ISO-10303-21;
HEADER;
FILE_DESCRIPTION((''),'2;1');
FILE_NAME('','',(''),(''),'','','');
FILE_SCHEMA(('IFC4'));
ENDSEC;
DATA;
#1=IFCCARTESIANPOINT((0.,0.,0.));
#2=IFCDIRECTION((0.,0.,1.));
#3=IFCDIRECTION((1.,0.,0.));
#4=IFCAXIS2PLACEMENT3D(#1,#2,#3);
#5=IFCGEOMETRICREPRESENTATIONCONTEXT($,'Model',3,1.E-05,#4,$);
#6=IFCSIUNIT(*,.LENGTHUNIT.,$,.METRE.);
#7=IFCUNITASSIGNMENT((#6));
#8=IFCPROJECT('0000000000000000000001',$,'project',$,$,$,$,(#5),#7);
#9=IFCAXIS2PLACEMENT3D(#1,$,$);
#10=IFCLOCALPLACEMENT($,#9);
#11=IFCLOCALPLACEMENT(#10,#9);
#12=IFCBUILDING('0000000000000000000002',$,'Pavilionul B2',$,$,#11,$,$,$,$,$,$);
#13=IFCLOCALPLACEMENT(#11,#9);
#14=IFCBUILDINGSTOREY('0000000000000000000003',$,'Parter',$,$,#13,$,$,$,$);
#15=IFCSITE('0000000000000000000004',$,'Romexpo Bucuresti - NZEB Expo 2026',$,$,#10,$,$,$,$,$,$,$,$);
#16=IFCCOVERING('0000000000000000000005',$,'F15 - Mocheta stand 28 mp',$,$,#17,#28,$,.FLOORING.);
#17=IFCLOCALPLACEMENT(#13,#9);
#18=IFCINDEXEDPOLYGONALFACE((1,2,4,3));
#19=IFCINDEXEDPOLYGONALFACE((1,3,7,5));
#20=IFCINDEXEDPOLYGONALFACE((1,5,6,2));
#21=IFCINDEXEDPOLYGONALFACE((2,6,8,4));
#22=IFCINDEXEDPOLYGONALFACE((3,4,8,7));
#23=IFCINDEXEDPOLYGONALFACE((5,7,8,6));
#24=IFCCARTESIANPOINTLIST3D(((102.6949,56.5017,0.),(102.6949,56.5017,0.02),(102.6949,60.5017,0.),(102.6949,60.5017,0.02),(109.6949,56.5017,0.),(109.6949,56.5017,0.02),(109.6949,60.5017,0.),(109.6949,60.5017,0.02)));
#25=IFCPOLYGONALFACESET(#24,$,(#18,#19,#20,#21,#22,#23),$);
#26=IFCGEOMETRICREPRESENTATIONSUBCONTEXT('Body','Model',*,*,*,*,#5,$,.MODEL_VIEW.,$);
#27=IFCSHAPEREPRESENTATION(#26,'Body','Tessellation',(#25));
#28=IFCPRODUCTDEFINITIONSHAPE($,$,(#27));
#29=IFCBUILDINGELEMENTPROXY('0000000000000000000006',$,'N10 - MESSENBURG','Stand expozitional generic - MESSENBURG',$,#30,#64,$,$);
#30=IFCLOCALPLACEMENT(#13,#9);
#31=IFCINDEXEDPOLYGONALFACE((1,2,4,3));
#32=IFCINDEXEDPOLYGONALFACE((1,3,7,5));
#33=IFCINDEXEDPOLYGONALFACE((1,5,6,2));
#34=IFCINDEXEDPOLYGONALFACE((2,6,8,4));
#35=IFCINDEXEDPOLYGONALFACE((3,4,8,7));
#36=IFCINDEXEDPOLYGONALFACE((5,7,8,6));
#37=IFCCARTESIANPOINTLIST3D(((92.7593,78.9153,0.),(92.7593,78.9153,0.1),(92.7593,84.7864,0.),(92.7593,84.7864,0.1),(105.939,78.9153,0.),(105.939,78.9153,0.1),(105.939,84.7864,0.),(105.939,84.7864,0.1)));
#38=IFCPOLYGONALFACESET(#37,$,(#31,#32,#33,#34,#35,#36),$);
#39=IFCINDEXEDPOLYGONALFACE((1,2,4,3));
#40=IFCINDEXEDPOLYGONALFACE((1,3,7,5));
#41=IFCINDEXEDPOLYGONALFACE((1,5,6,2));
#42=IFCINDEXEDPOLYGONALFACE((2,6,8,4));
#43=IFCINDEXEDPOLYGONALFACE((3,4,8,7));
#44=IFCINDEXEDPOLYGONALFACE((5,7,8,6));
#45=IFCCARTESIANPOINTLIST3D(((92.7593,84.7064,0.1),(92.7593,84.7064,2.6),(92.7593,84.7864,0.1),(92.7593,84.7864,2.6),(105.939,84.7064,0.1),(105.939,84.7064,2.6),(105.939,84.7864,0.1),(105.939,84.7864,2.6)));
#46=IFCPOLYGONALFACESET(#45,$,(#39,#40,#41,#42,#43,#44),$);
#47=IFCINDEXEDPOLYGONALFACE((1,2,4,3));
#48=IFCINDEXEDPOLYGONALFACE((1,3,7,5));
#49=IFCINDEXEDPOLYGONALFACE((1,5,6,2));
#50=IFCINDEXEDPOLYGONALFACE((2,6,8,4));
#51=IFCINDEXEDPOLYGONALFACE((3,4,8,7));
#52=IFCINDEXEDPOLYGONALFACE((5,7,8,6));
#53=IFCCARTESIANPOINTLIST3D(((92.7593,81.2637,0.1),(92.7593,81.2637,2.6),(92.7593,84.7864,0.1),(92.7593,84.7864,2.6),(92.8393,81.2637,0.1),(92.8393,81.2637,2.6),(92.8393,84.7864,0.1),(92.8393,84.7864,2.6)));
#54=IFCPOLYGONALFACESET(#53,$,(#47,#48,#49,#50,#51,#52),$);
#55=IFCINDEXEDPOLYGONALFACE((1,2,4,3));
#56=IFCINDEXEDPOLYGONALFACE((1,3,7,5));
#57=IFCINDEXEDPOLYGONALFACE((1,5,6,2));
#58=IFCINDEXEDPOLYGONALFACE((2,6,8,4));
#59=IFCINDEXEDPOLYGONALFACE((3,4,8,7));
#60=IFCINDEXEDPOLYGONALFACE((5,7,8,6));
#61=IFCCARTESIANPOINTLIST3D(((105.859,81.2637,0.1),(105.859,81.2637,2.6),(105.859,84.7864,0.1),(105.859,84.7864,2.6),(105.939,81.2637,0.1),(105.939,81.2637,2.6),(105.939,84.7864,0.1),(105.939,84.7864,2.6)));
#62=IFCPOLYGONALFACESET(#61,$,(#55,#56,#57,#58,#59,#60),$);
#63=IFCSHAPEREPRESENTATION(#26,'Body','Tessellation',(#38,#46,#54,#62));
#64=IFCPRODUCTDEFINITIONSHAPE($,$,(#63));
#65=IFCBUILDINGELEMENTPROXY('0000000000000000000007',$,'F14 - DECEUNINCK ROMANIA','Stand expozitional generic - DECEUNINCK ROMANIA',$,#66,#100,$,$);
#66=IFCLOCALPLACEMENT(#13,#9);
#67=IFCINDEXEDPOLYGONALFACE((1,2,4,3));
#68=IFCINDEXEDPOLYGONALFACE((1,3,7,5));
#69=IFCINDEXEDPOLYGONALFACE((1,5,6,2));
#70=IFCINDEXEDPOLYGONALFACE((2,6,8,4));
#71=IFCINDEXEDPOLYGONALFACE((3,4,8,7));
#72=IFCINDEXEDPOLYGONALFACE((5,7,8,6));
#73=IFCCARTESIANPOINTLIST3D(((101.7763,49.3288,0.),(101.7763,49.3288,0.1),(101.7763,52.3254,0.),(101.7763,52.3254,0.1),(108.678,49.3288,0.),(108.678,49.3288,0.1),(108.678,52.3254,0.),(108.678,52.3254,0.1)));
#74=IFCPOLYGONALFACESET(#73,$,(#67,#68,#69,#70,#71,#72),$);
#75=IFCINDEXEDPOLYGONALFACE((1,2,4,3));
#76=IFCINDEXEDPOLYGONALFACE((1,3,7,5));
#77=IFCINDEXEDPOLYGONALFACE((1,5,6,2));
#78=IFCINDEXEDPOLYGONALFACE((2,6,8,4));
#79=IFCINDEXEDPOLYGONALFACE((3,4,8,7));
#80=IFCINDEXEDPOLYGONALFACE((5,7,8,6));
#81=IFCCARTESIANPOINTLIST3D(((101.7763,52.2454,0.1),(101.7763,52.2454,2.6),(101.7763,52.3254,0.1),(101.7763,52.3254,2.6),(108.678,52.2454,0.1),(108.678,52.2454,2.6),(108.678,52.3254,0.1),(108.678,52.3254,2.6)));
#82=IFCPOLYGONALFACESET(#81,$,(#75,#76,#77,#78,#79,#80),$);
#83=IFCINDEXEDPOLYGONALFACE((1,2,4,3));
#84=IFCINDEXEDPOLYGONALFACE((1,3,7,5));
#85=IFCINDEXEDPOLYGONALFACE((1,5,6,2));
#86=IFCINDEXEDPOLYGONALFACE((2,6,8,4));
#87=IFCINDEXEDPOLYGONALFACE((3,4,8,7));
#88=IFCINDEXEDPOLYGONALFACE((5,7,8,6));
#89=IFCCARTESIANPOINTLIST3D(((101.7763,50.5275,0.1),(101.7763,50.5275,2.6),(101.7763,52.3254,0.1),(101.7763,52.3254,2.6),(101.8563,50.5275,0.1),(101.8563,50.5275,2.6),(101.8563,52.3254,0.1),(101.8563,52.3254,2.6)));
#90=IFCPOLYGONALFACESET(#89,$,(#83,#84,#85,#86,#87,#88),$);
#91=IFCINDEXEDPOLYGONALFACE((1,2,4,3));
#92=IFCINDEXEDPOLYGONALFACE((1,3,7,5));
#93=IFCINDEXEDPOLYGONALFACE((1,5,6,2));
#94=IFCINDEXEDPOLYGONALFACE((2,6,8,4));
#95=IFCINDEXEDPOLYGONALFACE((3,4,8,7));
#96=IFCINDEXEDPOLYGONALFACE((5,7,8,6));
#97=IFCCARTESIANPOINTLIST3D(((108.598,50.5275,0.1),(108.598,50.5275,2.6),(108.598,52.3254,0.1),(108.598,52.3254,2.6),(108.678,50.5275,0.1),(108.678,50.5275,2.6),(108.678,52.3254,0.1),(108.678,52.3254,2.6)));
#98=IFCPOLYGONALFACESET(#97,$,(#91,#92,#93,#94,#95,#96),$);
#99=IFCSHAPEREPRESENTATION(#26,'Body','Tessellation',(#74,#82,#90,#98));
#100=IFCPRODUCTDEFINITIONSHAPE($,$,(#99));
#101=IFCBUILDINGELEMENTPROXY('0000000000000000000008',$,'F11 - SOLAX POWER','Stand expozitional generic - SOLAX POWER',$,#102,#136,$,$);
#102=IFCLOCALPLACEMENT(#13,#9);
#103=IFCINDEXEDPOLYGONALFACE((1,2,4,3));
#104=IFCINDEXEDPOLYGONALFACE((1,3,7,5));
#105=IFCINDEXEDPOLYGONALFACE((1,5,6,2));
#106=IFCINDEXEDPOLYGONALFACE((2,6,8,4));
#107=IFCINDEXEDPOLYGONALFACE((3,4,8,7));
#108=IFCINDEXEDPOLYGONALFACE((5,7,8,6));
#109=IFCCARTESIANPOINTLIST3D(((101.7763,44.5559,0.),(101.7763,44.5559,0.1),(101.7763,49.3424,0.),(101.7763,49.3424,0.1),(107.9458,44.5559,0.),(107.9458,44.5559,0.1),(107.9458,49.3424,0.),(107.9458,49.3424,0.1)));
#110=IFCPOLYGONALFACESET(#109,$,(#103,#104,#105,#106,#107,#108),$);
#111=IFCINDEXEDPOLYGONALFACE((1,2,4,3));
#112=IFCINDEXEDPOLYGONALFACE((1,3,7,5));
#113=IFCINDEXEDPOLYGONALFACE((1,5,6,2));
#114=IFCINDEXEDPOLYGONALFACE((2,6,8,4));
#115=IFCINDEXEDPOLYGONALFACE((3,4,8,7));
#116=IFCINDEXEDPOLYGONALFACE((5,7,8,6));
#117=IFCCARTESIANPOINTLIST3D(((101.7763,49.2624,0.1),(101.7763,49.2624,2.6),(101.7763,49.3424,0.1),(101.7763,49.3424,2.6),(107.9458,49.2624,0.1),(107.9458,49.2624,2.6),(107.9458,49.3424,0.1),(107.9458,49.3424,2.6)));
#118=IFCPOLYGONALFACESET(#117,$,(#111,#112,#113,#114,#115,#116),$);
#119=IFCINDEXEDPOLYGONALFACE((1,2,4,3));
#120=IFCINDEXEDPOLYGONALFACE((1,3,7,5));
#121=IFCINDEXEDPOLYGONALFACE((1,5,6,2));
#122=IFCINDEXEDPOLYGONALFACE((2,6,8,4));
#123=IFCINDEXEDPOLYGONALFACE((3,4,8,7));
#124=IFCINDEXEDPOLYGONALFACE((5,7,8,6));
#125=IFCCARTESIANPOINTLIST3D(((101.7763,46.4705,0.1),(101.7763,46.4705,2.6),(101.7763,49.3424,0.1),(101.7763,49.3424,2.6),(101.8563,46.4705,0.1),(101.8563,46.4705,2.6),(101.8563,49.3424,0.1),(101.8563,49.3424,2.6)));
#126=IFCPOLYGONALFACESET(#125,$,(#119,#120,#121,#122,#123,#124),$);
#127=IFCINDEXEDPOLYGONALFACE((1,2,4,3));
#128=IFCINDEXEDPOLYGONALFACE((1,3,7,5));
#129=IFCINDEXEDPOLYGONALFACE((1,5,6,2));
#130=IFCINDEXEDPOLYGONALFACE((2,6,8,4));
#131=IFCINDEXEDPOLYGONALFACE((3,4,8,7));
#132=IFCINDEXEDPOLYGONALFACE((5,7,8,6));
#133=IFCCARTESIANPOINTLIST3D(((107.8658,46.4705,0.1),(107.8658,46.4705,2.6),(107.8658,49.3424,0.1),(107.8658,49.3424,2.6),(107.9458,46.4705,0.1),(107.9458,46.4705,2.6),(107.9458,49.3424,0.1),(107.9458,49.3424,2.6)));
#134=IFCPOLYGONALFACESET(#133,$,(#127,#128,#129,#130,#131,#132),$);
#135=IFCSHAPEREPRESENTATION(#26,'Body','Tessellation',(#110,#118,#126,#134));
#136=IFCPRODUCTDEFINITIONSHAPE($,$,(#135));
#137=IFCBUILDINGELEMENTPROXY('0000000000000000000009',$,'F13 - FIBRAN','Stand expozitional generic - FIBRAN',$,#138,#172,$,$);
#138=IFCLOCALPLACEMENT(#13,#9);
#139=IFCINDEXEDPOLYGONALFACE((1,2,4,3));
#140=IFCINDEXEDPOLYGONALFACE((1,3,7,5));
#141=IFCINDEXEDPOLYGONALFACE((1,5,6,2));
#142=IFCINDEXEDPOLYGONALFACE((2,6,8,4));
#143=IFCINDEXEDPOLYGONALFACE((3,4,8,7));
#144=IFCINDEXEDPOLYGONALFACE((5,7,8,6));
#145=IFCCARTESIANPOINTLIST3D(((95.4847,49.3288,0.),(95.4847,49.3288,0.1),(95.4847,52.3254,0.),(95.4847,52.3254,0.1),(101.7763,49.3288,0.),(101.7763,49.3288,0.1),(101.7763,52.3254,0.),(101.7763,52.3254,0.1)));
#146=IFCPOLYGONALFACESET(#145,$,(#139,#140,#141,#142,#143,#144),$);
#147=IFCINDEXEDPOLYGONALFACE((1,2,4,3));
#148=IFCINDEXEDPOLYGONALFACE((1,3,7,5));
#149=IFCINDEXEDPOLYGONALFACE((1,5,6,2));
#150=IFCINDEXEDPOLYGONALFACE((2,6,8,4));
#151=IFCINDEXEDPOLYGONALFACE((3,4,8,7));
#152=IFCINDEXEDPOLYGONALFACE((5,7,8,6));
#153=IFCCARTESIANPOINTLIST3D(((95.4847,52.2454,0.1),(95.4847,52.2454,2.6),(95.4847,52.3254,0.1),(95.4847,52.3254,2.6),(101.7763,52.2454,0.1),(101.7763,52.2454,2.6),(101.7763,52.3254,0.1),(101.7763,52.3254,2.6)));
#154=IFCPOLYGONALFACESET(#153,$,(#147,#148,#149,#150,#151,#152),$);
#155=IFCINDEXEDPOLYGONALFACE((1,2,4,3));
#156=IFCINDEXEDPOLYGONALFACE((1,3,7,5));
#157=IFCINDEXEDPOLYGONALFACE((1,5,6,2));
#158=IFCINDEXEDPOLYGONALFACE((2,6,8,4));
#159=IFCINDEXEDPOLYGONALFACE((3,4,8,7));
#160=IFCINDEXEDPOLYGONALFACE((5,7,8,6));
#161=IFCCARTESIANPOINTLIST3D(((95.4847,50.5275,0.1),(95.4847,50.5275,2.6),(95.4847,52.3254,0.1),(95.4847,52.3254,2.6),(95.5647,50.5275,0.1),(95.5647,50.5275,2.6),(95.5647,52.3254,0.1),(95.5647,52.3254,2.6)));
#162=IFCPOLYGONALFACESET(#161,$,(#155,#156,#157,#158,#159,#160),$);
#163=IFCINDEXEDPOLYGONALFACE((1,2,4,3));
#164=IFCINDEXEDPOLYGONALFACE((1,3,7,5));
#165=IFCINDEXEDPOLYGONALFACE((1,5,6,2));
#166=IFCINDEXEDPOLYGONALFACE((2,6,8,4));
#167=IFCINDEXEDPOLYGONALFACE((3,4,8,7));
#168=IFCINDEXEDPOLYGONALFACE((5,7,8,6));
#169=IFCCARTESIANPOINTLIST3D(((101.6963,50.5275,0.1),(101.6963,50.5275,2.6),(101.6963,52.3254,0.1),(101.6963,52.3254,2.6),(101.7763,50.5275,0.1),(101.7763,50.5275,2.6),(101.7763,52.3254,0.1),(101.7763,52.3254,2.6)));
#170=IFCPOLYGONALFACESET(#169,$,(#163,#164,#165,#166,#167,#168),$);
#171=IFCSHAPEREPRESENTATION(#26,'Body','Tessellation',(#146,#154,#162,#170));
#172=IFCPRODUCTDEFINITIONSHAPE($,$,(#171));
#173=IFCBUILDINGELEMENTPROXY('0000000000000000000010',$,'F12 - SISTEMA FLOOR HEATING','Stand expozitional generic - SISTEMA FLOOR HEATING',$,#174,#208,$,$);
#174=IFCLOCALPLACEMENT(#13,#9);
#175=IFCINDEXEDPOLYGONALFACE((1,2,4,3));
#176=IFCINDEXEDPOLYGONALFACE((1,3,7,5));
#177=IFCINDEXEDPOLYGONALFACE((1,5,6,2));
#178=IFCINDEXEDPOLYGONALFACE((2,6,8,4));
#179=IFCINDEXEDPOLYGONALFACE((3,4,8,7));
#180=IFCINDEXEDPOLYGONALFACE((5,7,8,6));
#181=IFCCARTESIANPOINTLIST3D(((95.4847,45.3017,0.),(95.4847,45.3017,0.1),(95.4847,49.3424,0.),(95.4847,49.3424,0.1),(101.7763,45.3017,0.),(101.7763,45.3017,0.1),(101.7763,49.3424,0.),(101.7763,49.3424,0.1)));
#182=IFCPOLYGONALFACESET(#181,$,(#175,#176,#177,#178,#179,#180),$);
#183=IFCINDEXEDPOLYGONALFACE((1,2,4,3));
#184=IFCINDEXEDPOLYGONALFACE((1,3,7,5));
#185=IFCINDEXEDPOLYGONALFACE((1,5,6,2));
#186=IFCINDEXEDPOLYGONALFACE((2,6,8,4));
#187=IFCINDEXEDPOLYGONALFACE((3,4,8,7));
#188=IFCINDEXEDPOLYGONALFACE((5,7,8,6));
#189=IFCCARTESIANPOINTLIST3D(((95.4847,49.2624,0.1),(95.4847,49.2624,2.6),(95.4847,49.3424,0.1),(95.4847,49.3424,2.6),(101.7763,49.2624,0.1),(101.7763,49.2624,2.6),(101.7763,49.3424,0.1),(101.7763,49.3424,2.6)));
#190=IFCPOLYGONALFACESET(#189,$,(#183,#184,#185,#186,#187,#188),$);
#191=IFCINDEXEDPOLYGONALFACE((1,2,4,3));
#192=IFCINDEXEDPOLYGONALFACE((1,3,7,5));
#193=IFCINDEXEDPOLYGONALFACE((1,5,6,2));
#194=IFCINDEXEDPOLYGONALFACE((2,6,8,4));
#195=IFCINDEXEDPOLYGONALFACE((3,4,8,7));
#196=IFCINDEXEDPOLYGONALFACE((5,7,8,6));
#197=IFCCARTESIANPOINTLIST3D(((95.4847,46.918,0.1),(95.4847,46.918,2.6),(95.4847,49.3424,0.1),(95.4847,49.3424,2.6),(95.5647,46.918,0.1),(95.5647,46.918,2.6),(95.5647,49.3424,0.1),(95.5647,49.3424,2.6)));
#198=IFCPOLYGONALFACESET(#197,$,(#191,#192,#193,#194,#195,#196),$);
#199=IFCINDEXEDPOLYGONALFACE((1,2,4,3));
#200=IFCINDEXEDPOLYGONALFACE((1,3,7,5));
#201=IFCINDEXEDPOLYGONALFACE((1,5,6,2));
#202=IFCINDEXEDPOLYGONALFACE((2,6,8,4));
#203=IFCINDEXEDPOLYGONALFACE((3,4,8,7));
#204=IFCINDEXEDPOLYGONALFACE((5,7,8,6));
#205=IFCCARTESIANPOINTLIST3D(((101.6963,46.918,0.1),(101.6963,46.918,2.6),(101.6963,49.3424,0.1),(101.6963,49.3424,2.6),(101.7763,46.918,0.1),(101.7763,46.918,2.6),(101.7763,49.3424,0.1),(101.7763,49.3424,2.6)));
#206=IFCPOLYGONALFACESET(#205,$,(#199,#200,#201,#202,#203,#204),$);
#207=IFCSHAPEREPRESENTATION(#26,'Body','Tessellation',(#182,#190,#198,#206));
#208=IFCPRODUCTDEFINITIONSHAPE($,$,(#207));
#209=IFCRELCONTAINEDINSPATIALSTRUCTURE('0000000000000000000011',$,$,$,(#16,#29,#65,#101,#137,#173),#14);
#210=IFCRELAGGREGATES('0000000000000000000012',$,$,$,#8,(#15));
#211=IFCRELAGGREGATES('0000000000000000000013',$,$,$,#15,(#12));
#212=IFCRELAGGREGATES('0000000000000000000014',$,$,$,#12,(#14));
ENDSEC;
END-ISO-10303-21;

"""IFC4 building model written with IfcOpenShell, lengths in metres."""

from ifc_helpers import new_model, si_unit, frame, frame_2d, origin, origin_with_axes, place, context, subcontext, project, spatial, rectangle, extrude, element, save


model = new_model("IFC4")

# Units and contexts
model_context = context("Model", 3, precision=1e-05, world=origin_with_axes())
body_context = subcontext(model_context, "Body", "Model", "MODEL_VIEW")
ifc_project = project(units=[si_unit("LENGTHUNIT", "METRE")], contexts=[model_context])

# Site, building, storey
site_placement = place(None, origin())
site = spatial("IfcSite", under=ifc_project, at=site_placement, Name="Romexpo Bucuresti - NZEB Expo 2026")
building_placement = place(site_placement, origin())
building = spatial("IfcBuilding", under=site, at=building_placement, Name="Pavilionul B2")
storey_placement = place(building_placement, origin())
storey = spatial("IfcBuildingStorey", under=building, at=storey_placement, Name="Parter")

# Covering
covering_placement = place(storey_placement, frame((102.6949, 56.5017, 0.0), z_axis=(0.0, 0.0, 1.0), x_axis=(1.0, 0.0, 0.0)))
element("IfcCovering", 1, at=covering_placement, inside=storey, Name="F15 - Mocheta stand 28 mp", PredefinedType="FLOORING", context=body_context, shape_type="SweptSolid", body=[
    extrude(rectangle(XDim=7.0, YDim=4.0, at=frame_2d((3.5, 2.0))), origin(), (0.0, 0.0, 1.0), 0.02),
])

# Building element proxies
proxy_1_placement = place(storey_placement, frame((92.7593, 78.9153, 0.0), z_axis=(0.0, 0.0, 1.0), x_axis=(1.0, 0.0, 0.0)))
element("IfcBuildingElementProxy", 2, at=proxy_1_placement, inside=storey, Name="N10 - MESSENBURG", Description="Stand expozitional generic - MESSENBURG", context=body_context, shape_type="SweptSolid", body=[
    extrude(rectangle(XDim=13.1797, YDim=5.8712, at=frame_2d((6.5898, 2.9356))), origin(), (0.0, 0.0, 1.0), 0.1),
    extrude(rectangle(XDim=13.1797, YDim=0.08, at=frame_2d((6.5898, 5.8312))), frame((0.0, 0.0, 0.1)), (0.0, 0.0, 1.0), 2.5),
    extrude(rectangle(XDim=0.08, YDim=3.5227, at=frame_2d((0.04, 4.1098))), frame((0.0, 0.0, 0.1)), (0.0, 0.0, 1.0), 2.5),
    extrude(rectangle(XDim=0.08, YDim=3.5227, at=frame_2d((13.1397, 4.1098))), frame((0.0, 0.0, 0.1)), (0.0, 0.0, 1.0), 2.5),
])
proxy_2_placement = place(storey_placement, frame((101.7763, 49.3288, 0.0), z_axis=(0.0, 0.0, 1.0), x_axis=(1.0, 0.0, 0.0)))
element("IfcBuildingElementProxy", 3, at=proxy_2_placement, inside=storey, Name="F14 - DECEUNINCK ROMANIA", Description="Stand expozitional generic - DECEUNINCK ROMANIA", context=body_context, shape_type="SweptSolid", body=[
    extrude(rectangle(XDim=6.9017, YDim=2.9966, at=frame_2d((3.4508, 1.4983))), origin(), (0.0, 0.0, 1.0), 0.1),
    extrude(rectangle(XDim=6.9017, YDim=0.08, at=frame_2d((3.4508, 2.9566))), frame((0.0, 0.0, 0.1)), (0.0, 0.0, 1.0), 2.5),
    extrude(rectangle(XDim=0.08, YDim=1.798, at=frame_2d((0.04, 2.0976))), frame((0.0, 0.0, 0.1)), (0.0, 0.0, 1.0), 2.5),
    extrude(rectangle(XDim=0.08, YDim=1.798, at=frame_2d((6.8617, 2.0976))), frame((0.0, 0.0, 0.1)), (0.0, 0.0, 1.0), 2.5),
])
proxy_3_placement = place(storey_placement, frame((101.7763, 44.5559, 0.0), z_axis=(0.0, 0.0, 1.0), x_axis=(1.0, 0.0, 0.0)))
element("IfcBuildingElementProxy", 4, at=proxy_3_placement, inside=storey, Name="F11 - SOLAX POWER", Description="Stand expozitional generic - SOLAX POWER", context=body_context, shape_type="SweptSolid", body=[
    extrude(rectangle(XDim=6.1695, YDim=4.7864, at=frame_2d((3.0847, 2.3932))), origin(), (0.0, 0.0, 1.0), 0.1),
    extrude(rectangle(XDim=6.1695, YDim=0.08, at=frame_2d((3.0847, 4.7464))), frame((0.0, 0.0, 0.1)), (0.0, 0.0, 1.0), 2.5),
    extrude(rectangle(XDim=0.08, YDim=2.8719, at=frame_2d((0.04, 3.3505))), frame((0.0, 0.0, 0.1)), (0.0, 0.0, 1.0), 2.5),
    extrude(rectangle(XDim=0.08, YDim=2.8719, at=frame_2d((6.1295, 3.3505))), frame((0.0, 0.0, 0.1)), (0.0, 0.0, 1.0), 2.5),
])
proxy_4_placement = place(storey_placement, frame((95.4847, 49.3288, 0.0), z_axis=(0.0, 0.0, 1.0), x_axis=(1.0, 0.0, 0.0)))
element("IfcBuildingElementProxy", 5, at=proxy_4_placement, inside=storey, Name="F13 - FIBRAN", Description="Stand expozitional generic - FIBRAN", context=body_context, shape_type="SweptSolid", body=[
    extrude(rectangle(XDim=6.2915, YDim=2.9966, at=frame_2d((3.1458, 1.4983))), origin(), (0.0, 0.0, 1.0), 0.1),
    extrude(rectangle(XDim=6.2915, YDim=0.08, at=frame_2d((3.1458, 2.9566))), frame((0.0, 0.0, 0.1)), (0.0, 0.0, 1.0), 2.5),
    extrude(rectangle(XDim=0.08, YDim=1.798, at=frame_2d((0.04, 2.0976))), frame((0.0, 0.0, 0.1)), (0.0, 0.0, 1.0), 2.5),
    extrude(rectangle(XDim=0.08, YDim=1.798, at=frame_2d((6.2515, 2.0976))), frame((0.0, 0.0, 0.1)), (0.0, 0.0, 1.0), 2.5),
])
proxy_5_placement = place(storey_placement, frame((95.4847, 45.3017, 0.0), z_axis=(0.0, 0.0, 1.0), x_axis=(1.0, 0.0, 0.0)))
element("IfcBuildingElementProxy", 6, at=proxy_5_placement, inside=storey, Name="F12 - SISTEMA FLOOR HEATING", Description="Stand expozitional generic - SISTEMA FLOOR HEATING", context=body_context, shape_type="SweptSolid", body=[
    extrude(rectangle(XDim=6.2915, YDim=4.0407, at=frame_2d((3.1458, 2.0203))), origin(), (0.0, 0.0, 1.0), 0.1),
    extrude(rectangle(XDim=6.2915, YDim=0.08, at=frame_2d((3.1458, 4.0007))), frame((0.0, 0.0, 0.1)), (0.0, 0.0, 1.0), 2.5),
    extrude(rectangle(XDim=0.08, YDim=2.4244, at=frame_2d((0.04, 2.8285))), frame((0.0, 0.0, 0.1)), (0.0, 0.0, 1.0), 2.5),
    extrude(rectangle(XDim=0.08, YDim=2.4244, at=frame_2d((6.2515, 2.8285))), frame((0.0, 0.0, 0.1)), (0.0, 0.0, 1.0), 2.5),
])

save(model, "model.ifc")
